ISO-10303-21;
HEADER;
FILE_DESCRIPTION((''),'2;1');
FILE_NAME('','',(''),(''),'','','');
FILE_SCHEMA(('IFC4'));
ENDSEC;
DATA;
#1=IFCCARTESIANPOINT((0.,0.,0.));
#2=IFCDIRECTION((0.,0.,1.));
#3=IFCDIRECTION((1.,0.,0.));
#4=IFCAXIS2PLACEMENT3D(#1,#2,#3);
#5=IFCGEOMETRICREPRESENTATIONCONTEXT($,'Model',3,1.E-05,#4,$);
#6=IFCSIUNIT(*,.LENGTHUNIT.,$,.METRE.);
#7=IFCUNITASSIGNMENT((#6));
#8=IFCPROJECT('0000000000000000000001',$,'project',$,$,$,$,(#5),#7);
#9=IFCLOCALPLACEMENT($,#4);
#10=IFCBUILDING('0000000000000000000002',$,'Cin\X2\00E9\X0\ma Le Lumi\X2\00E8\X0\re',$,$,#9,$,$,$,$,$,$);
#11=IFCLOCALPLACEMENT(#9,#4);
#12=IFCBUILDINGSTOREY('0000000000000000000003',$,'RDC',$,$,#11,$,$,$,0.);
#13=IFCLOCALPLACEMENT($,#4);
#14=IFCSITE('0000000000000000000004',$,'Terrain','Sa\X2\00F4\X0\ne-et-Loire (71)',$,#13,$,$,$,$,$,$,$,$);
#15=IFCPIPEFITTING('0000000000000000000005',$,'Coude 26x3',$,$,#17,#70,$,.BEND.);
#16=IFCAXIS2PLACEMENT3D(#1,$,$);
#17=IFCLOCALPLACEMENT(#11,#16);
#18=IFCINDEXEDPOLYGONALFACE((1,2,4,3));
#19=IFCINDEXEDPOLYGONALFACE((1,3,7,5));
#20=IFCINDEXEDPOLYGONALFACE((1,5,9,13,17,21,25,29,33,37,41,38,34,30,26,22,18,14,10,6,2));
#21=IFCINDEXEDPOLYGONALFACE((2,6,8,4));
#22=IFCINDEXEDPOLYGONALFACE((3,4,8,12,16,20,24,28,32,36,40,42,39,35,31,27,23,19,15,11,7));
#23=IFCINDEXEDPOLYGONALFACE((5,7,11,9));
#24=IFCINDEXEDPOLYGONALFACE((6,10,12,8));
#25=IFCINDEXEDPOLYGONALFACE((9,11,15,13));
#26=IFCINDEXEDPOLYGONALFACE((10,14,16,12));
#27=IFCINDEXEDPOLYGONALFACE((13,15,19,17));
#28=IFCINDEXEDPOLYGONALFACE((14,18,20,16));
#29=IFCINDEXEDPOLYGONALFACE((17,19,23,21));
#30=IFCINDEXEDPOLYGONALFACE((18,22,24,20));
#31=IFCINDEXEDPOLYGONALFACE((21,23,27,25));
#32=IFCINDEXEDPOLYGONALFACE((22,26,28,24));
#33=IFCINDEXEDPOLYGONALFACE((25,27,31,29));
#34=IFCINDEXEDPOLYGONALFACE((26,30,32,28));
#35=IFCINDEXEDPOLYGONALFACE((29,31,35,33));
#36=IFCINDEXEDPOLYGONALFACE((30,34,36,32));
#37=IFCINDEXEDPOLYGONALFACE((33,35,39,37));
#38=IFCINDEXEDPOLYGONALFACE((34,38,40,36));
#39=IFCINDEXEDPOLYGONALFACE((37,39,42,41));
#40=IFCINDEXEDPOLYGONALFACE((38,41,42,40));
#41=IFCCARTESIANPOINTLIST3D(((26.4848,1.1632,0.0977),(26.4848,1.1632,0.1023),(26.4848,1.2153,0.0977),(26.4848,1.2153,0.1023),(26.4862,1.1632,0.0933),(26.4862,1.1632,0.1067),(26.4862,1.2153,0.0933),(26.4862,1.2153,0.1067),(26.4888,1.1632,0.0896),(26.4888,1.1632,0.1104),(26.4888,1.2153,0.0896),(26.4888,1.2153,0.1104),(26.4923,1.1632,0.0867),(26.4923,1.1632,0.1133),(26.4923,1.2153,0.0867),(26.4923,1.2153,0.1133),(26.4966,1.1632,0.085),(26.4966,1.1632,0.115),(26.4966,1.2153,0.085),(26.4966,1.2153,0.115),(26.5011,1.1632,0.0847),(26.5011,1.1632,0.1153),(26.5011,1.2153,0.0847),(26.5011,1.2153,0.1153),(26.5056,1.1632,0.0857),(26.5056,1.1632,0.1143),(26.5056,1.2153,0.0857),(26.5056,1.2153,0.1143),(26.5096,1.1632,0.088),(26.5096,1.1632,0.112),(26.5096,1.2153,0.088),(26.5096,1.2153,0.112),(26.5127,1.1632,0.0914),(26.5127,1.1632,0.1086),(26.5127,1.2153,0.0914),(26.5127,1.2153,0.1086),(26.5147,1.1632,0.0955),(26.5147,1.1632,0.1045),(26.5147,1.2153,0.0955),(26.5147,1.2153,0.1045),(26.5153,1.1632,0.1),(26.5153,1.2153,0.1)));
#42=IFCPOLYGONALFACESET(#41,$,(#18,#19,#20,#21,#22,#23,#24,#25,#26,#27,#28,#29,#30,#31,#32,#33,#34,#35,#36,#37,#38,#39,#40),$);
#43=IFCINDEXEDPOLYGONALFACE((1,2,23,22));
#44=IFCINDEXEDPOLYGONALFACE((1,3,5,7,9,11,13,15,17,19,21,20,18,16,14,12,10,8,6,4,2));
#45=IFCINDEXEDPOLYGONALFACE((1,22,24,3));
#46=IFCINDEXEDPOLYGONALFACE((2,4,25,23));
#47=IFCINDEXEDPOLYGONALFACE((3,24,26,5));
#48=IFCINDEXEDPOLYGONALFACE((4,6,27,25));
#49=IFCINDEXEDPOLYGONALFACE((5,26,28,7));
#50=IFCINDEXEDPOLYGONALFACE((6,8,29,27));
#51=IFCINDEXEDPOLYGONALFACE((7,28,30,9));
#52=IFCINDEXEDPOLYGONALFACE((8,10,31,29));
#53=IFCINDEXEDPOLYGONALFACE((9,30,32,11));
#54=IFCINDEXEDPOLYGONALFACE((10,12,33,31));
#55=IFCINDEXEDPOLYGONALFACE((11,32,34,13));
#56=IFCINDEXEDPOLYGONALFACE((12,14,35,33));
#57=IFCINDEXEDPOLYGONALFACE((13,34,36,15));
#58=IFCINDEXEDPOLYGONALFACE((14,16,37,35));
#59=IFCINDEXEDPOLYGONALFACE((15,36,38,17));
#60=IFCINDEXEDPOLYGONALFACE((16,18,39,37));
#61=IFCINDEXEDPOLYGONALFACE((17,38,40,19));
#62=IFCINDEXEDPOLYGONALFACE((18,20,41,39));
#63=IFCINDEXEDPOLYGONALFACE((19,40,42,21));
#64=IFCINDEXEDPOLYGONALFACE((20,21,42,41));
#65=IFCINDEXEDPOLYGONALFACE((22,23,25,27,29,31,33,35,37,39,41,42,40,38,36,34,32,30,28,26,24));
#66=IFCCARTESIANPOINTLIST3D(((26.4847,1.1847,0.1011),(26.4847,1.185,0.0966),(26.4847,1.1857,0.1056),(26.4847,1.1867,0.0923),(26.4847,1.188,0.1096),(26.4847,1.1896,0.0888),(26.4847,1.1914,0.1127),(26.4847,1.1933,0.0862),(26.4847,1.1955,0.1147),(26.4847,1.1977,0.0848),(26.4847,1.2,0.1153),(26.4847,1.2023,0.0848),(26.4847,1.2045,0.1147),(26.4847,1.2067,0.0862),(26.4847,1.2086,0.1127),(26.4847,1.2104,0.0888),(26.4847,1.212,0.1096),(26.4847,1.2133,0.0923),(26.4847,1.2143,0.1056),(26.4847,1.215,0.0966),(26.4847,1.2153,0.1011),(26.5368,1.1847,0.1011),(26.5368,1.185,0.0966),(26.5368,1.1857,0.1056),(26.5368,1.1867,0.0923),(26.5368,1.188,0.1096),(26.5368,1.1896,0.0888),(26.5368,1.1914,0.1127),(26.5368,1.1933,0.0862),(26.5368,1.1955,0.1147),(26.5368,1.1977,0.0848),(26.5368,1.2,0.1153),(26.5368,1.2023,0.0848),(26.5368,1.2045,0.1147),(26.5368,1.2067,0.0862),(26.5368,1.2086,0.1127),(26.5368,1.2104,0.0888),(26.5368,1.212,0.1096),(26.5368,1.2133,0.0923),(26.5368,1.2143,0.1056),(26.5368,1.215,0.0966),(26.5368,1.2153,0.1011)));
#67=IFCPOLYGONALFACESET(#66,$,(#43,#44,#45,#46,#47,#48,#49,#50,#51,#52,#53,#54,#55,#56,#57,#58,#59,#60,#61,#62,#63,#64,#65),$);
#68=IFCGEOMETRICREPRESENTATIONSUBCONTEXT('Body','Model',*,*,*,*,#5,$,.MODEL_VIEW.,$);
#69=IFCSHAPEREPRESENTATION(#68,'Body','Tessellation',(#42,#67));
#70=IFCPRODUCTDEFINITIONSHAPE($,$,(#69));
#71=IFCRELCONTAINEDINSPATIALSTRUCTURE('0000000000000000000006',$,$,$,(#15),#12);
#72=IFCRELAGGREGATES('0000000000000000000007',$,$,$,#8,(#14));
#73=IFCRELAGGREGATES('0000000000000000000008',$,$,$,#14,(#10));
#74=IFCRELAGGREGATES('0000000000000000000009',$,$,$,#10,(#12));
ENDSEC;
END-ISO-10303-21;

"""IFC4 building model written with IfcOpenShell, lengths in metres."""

from ifc_helpers import new_model, si_unit, frame, origin_with_axes, place, context, subcontext, project, spatial, circle, extrude, element, save


model = new_model("IFC4")

# Units and contexts
model_context = context("Model", 3, precision=1e-05, world=origin_with_axes())
body_context = subcontext(model_context, "Body", "Model", "MODEL_VIEW")
ifc_project = project(units=[si_unit("LENGTHUNIT", "METRE")], contexts=[model_context])

# Site, building, storey
site_placement = place(None, origin_with_axes())
site = spatial("IfcSite", under=ifc_project, at=site_placement, Name="Terrain", Description="Saône-et-Loire (71)")
building_placement = place(None, origin_with_axes())
building = spatial("IfcBuilding", under=site, at=building_placement, Name="Cinéma Le Lumière")
storey_placement = place(building_placement, origin_with_axes())
storey = spatial("IfcBuildingStorey", under=building, at=storey_placement, Name="RDC", Elevation=0.0)

# Pipe fitting
pipe_fitting_placement = place(storey_placement, frame((26.5, 1.2, 0.1), z_axis=(0.0, 0.0, 1.0), x_axis=(1.0, 0.0, 0.0)))
element("IfcPipeFitting", 1, at=pipe_fitting_placement, inside=storey, Name="Coude 26x3", PredefinedType="BEND", context=body_context, shape_type="SweptSolid", body=[
    extrude(circle(Radius=0.0153), frame((0.0, 0.0153, 0.0), z_axis=(0.0, -1.0, 0.0), x_axis=(1.0, 0.0, 0.0)), (0.0, 0.0, 1.0), 0.0522),
    extrude(circle(Radius=0.0153), frame((-0.0153, 0.0, 0.0), z_axis=(1.0, 0.0, 0.0), x_axis=(0.0, 0.0, 1.0)), (0.0, 0.0, 1.0), 0.0522),
])

save(model, "model.ifc")
